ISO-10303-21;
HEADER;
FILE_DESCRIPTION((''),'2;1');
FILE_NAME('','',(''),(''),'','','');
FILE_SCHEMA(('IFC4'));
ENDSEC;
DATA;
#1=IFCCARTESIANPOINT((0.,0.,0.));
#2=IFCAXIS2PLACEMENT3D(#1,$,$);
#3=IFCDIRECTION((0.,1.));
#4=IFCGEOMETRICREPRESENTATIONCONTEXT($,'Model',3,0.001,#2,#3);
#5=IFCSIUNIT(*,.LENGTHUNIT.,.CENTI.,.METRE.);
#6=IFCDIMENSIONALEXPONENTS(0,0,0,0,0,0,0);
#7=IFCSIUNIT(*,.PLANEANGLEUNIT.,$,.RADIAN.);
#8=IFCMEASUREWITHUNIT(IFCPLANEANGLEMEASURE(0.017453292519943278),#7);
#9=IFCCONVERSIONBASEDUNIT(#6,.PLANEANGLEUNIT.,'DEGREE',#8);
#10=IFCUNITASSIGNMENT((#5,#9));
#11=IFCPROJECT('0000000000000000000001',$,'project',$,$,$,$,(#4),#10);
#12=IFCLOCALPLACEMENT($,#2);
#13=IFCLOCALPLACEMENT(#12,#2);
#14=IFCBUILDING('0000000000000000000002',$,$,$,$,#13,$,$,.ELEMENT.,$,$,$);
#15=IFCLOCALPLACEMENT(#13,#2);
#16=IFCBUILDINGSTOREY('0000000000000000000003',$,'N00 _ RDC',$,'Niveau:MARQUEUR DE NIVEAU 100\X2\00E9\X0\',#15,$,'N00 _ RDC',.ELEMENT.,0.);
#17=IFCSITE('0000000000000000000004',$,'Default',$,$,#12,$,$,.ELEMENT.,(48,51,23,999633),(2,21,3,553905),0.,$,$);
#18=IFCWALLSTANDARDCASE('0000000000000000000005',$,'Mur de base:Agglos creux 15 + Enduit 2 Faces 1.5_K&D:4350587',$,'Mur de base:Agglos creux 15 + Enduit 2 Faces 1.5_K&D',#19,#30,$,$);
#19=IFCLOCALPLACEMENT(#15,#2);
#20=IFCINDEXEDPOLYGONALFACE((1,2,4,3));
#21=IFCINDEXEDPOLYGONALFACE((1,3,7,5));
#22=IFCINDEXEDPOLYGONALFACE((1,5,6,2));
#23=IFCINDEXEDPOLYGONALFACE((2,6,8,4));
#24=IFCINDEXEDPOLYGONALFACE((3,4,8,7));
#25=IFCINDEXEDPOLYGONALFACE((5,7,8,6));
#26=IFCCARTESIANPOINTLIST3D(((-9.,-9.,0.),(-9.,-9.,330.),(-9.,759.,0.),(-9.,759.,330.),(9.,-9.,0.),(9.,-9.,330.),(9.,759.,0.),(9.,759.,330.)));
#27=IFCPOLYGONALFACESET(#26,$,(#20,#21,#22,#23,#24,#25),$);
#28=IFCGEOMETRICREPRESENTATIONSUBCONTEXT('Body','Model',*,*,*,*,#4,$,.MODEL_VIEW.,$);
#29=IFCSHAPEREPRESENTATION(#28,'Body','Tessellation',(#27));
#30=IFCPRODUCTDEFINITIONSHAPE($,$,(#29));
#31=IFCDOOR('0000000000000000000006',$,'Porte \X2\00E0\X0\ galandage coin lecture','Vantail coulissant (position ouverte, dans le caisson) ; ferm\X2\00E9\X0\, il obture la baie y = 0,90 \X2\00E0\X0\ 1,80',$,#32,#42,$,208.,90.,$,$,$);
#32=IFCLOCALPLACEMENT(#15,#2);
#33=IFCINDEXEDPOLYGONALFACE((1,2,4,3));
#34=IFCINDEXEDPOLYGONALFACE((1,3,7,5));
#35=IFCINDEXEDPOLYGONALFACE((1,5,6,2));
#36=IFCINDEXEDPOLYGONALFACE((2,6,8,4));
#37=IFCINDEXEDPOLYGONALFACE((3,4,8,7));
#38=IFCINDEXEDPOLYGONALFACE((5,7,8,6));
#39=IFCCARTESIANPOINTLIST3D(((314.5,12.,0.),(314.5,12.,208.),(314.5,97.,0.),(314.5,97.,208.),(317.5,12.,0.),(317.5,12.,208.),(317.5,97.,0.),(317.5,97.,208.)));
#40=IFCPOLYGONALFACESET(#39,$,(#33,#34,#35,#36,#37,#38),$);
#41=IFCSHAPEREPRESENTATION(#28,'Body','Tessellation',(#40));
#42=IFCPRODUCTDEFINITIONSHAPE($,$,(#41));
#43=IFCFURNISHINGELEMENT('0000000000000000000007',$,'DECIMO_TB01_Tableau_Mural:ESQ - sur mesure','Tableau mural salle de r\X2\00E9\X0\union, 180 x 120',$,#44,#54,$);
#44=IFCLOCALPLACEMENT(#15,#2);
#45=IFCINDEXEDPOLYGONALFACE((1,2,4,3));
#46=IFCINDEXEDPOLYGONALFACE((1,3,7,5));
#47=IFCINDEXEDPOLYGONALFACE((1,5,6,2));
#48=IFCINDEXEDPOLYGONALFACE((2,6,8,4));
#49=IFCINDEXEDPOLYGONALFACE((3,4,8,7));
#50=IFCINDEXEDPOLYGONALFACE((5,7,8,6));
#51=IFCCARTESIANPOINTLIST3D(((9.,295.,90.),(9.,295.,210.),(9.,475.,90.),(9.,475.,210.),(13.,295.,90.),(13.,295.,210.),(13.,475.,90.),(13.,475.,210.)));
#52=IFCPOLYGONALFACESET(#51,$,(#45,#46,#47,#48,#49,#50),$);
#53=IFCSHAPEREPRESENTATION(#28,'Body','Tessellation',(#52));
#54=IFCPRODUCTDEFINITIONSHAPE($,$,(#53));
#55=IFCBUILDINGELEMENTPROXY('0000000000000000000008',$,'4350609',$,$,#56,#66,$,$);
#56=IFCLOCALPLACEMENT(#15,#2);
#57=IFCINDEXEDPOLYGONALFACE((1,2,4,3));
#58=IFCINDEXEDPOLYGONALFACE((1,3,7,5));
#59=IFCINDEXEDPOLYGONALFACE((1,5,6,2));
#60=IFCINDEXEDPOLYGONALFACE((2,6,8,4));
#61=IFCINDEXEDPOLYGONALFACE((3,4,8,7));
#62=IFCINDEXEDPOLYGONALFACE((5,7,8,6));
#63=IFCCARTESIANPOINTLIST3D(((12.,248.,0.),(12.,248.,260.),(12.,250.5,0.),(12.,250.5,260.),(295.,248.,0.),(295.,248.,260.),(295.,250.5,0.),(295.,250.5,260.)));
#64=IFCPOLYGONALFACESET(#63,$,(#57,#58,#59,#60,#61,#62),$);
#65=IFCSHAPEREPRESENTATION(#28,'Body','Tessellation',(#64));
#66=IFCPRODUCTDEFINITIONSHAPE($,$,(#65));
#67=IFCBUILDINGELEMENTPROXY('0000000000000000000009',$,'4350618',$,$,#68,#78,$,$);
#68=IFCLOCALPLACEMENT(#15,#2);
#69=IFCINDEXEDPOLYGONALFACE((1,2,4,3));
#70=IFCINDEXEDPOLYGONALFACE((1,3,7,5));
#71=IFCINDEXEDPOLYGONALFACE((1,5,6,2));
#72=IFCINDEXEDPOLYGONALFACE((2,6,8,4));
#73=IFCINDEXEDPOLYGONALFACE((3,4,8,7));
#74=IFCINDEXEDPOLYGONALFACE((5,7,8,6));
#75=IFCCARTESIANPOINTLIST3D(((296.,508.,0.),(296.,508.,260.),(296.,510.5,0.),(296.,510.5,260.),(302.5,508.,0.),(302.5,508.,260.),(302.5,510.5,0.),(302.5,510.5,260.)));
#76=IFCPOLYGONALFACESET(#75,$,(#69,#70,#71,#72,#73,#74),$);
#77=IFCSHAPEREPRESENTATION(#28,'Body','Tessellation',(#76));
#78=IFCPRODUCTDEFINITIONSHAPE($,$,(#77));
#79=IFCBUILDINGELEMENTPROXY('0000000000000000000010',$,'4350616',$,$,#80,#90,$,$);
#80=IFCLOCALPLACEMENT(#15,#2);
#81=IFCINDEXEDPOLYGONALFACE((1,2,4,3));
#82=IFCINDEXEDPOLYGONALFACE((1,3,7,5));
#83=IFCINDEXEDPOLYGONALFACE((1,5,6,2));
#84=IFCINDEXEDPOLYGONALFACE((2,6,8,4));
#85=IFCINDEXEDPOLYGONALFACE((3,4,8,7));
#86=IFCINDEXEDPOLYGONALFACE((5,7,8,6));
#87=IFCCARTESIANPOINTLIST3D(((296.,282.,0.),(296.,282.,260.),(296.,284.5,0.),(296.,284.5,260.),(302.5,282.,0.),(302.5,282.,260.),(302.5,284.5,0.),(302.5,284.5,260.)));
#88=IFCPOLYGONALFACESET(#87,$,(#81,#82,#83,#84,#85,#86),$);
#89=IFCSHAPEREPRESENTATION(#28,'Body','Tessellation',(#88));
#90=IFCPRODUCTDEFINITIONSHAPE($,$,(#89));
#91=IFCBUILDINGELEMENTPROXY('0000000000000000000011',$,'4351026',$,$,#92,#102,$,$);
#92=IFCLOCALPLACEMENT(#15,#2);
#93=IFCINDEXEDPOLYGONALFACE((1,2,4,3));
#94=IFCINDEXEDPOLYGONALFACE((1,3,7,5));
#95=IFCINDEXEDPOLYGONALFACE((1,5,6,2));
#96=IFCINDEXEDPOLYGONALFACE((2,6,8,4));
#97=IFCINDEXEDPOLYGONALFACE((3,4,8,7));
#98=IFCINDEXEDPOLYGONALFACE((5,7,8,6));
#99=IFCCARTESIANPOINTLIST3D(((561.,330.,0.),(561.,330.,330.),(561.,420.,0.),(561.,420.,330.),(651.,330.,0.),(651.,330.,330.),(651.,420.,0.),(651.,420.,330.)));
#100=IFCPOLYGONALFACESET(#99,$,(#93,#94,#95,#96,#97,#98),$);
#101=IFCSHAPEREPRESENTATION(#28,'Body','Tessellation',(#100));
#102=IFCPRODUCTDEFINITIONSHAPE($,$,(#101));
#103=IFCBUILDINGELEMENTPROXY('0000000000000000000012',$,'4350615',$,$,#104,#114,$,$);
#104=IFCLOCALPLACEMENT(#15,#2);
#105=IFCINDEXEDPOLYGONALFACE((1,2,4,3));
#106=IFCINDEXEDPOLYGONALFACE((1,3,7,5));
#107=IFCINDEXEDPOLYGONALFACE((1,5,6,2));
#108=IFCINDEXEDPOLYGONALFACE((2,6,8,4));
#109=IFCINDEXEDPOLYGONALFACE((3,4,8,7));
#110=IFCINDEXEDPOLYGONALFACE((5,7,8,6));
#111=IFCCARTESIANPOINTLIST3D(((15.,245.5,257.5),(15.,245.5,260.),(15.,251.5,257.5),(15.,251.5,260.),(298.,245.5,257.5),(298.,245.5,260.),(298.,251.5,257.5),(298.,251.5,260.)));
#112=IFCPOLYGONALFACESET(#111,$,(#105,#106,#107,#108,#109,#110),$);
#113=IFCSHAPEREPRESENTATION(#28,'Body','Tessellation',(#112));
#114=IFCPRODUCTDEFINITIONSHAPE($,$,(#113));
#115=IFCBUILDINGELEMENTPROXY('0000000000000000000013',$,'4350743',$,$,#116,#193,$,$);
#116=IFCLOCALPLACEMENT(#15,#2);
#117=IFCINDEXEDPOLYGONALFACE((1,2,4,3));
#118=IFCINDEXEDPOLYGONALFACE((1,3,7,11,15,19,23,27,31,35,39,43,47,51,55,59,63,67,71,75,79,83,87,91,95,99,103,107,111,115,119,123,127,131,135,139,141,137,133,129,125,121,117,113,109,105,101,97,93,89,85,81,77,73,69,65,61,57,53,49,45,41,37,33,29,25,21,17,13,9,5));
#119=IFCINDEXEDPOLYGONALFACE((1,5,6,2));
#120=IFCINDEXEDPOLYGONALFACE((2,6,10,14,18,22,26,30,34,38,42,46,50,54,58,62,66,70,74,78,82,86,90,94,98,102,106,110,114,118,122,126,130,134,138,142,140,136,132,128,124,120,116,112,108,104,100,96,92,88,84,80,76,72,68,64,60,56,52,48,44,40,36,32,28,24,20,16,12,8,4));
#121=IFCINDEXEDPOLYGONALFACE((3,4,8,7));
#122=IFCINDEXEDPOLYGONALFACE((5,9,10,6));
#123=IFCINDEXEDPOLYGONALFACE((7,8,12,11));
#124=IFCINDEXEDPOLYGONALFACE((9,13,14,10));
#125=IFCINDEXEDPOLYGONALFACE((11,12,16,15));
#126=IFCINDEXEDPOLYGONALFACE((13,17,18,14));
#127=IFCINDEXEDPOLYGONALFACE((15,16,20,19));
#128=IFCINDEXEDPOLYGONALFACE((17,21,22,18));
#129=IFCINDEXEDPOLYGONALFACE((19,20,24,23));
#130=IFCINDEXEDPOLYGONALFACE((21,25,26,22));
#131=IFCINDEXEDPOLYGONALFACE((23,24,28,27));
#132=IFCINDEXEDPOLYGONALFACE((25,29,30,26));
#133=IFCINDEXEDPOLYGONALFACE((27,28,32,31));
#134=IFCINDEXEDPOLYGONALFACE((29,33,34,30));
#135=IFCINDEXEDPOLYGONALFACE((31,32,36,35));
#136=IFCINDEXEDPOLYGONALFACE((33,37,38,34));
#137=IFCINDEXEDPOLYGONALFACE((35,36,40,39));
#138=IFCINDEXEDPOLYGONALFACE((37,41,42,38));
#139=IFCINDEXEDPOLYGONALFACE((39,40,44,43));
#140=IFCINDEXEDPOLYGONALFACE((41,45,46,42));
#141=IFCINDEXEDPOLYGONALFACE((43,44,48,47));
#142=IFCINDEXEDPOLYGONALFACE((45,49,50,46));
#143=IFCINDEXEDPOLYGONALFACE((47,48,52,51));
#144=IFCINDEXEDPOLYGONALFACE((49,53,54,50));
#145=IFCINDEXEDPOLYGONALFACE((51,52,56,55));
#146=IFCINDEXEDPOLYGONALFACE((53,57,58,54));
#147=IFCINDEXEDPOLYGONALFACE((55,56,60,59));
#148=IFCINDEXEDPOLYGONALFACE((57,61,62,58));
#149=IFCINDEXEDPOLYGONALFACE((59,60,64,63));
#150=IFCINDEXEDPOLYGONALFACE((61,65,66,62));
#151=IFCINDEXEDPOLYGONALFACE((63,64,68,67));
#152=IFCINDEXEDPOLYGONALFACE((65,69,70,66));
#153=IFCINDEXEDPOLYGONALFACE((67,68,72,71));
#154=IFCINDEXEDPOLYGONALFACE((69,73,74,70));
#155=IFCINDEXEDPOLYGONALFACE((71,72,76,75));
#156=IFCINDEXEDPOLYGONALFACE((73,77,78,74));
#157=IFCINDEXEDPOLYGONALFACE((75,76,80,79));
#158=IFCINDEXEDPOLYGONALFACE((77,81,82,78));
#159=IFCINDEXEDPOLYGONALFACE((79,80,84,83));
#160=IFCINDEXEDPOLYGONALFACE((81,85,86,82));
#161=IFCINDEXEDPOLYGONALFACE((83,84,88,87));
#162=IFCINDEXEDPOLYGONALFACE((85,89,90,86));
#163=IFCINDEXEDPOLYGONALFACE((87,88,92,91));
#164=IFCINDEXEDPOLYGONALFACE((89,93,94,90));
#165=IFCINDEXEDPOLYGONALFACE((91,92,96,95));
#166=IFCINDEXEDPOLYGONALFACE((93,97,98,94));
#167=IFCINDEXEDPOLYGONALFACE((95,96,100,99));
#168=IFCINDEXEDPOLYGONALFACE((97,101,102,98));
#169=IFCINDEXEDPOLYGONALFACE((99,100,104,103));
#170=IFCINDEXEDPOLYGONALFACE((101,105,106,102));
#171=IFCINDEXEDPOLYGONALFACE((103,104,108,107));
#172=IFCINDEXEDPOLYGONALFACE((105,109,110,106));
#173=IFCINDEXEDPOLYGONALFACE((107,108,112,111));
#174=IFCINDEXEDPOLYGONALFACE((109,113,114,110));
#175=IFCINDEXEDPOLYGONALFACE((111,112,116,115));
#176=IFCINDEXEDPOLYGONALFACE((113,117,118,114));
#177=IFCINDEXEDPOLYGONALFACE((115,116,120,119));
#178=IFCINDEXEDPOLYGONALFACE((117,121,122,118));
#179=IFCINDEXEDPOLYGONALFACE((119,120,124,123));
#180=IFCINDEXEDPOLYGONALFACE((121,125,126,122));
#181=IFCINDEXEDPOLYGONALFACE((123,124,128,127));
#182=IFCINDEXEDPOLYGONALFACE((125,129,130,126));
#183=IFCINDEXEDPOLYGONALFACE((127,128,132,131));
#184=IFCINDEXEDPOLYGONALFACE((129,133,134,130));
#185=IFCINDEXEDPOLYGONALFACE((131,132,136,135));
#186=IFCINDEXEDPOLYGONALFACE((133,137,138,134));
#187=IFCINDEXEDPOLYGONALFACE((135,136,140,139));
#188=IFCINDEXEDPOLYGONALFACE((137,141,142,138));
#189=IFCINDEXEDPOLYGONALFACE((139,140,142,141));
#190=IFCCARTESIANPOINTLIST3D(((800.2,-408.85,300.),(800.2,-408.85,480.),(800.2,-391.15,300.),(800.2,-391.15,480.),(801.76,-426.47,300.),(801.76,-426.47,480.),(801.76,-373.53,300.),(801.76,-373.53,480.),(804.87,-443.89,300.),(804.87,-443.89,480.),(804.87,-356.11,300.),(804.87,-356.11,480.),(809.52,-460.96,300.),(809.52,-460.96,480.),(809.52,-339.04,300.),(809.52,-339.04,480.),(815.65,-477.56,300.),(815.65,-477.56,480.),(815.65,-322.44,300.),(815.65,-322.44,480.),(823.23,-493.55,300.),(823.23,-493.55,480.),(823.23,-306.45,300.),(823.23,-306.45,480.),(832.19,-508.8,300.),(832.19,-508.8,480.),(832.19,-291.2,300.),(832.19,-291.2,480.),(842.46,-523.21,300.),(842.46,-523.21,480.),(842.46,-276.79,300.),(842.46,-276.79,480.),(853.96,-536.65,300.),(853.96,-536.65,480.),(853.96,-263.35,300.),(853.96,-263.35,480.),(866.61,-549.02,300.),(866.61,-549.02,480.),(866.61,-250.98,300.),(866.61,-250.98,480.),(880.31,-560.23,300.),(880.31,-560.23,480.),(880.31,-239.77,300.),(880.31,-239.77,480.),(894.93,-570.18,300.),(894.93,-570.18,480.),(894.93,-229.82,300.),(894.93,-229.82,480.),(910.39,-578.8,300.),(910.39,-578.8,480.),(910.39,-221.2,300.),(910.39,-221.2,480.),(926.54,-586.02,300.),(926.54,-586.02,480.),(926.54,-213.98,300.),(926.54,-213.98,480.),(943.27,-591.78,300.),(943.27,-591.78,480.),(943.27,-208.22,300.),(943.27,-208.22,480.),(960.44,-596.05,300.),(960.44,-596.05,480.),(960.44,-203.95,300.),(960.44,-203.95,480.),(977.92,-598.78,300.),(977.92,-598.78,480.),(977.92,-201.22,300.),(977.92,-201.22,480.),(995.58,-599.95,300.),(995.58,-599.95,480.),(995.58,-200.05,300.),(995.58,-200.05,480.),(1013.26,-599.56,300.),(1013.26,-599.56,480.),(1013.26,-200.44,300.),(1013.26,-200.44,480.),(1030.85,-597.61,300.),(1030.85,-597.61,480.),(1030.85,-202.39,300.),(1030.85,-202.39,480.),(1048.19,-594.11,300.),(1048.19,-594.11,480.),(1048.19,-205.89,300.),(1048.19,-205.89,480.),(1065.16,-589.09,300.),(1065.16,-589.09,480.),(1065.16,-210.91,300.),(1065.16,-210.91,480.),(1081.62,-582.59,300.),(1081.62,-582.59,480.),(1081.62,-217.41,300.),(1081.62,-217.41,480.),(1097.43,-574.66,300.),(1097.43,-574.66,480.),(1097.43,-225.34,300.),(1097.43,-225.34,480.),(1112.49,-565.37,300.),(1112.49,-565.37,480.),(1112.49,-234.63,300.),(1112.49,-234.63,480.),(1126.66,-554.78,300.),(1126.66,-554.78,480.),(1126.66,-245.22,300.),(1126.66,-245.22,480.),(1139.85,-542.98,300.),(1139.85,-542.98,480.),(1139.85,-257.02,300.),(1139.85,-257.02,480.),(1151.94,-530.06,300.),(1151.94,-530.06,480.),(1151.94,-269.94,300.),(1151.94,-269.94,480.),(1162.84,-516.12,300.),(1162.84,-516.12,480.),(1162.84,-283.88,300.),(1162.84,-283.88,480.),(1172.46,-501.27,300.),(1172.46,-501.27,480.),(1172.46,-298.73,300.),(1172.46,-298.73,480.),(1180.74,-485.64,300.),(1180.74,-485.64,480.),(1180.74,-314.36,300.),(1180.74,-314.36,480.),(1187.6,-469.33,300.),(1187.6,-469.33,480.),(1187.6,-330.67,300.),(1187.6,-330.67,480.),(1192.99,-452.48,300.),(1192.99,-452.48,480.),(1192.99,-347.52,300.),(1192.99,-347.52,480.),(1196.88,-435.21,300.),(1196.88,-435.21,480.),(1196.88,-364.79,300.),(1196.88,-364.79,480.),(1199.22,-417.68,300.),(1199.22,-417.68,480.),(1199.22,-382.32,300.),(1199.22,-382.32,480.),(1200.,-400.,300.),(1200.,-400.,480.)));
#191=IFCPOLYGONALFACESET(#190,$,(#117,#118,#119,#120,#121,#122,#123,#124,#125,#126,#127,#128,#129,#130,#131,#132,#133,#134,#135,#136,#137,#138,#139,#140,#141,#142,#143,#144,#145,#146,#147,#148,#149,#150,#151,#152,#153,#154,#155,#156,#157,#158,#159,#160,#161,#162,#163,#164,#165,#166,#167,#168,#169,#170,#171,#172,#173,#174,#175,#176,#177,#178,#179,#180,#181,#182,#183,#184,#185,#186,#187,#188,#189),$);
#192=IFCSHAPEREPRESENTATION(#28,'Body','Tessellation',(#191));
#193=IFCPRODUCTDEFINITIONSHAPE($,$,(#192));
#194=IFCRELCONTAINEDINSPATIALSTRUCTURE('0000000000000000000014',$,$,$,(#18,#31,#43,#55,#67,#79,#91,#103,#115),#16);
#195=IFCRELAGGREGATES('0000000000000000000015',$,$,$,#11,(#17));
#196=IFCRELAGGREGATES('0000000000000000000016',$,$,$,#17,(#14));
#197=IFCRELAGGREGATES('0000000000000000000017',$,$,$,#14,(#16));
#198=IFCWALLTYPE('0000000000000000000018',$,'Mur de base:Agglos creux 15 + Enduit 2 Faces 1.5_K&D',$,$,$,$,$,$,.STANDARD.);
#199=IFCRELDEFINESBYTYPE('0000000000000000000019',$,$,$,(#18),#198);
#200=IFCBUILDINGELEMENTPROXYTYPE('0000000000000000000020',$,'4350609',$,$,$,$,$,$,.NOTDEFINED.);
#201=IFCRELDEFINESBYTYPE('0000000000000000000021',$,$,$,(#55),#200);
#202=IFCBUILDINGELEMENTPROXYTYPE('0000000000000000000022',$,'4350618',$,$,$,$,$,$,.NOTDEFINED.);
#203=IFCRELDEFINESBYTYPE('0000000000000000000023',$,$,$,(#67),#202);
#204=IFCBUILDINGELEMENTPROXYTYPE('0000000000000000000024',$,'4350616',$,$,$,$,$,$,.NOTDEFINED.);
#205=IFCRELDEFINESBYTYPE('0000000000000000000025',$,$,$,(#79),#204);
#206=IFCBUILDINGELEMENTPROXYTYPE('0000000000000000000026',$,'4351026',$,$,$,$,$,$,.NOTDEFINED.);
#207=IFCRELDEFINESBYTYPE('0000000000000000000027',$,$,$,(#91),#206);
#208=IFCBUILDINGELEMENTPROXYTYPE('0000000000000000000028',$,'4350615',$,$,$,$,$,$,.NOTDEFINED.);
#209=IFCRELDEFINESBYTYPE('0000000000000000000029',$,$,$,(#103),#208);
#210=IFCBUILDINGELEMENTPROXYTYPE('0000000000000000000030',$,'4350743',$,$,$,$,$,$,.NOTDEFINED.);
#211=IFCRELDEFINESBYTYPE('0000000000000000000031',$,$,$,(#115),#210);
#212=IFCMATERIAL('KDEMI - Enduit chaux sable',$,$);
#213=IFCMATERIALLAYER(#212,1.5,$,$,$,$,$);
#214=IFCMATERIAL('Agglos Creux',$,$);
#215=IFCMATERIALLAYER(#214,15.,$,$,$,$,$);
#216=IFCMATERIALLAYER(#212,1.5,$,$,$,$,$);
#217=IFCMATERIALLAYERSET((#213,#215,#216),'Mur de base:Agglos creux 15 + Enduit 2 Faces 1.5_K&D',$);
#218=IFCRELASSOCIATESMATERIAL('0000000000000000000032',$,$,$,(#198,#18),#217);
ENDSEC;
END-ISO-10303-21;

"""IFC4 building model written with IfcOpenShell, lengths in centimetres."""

from ifc_helpers import new_model, entity, si_unit, converted_unit, direction, frame, frame_2d, origin, origin_with_axes, origin_2d_with_axis, place, context, subcontext, project, spatial, rectangle, circle, extrude, material, layer, layer_set, layer_usage, type_object, element, save


model = new_model("IFC4")

# Units and contexts
model_context = context("Model", 3, precision=0.001, world=origin(), true_north=direction((0.0, 1.0)))
body_context = subcontext(model_context, "Body", "Model", "MODEL_VIEW")
ifc_project = project(units=[si_unit("LENGTHUNIT", "METRE", prefix="CENTI"), converted_unit("PLANEANGLEUNIT", "DEGREE", entity("IfcPlaneAngleMeasure", 0.017453292519943278), si_unit("PLANEANGLEUNIT", "RADIAN"), dimensions=[0, 0, 0, 0, 0, 0, 0])], contexts=[model_context])

# Site, building, storey
site_placement = place(None, origin())
site = spatial("IfcSite", under=ifc_project, at=site_placement, Name="Default", CompositionType="ELEMENT", RefLatitude=(48, 51, 23, 999633), RefLongitude=(2, 21, 3, 553905), RefElevation=0.0)
building_placement = place(site_placement, origin())
building = spatial("IfcBuilding", under=site, at=building_placement, CompositionType="ELEMENT")
storey_placement = place(building_placement, origin())
storey = spatial("IfcBuildingStorey", under=building, at=storey_placement, Name="N00 _ RDC", ObjectType="Niveau:MARQUEUR DE NIVEAU 100é", LongName="N00 _ RDC", CompositionType="ELEMENT", Elevation=0.0)

# Wall
ifc_material_1 = material(Name="KDEMI - Enduit chaux sable")
ifc_layer_1 = layer(ifc_material_1, 1.5)
ifc_material_2 = material(Name="Agglos Creux")
ifc_layer_2 = layer(ifc_material_2, 15.0)
ifc_layer_3 = layer(ifc_material_1, 1.5)
ifc_layer_set = layer_set([ifc_layer_1, ifc_layer_2, ifc_layer_3], Name="Mur de base:Agglos creux 15 + Enduit 2 Faces 1.5_K&D")
ifc_layer_usage = layer_usage(ifc_layer_set, "AXIS2", "NEGATIVE", 9.0)
wall_type = type_object("IfcWallType", Name="Mur de base:Agglos creux 15 + Enduit 2 Faces 1.5_K&D", PredefinedType="STANDARD", material=ifc_layer_set)
wall_placement = place(storey_placement, frame((0.0, -9.0, 0.0), z_axis=(0.0, 0.0, 1.0), x_axis=(0.0, 1.0, 0.0)))
element("IfcWallStandardCase", 1, at=wall_placement, inside=storey, type_object=wall_type, material=ifc_layer_usage, Name="Mur de base:Agglos creux 15 + Enduit 2 Faces 1.5_K&D:4350587", ObjectType="Mur de base:Agglos creux 15 + Enduit 2 Faces 1.5_K&D", context=body_context, shape_type="SweptSolid", body=[
    extrude(rectangle(XDim=768.0, YDim=18.0, at=frame_2d((384.0, 0.0), x_axis=(-1.0, 0.0))), origin(), (0.0, 0.0, 1.0), 330.0),
])

# Door
door_placement = place(storey_placement, origin_with_axes())
element("IfcDoor", 2, at=door_placement, inside=storey, Name="Porte à galandage coin lecture", Description="Vantail coulissant (position ouverte, dans le caisson) ; fermé, il obture la baie y = 0,90 à 1,80", OverallHeight=208.0, OverallWidth=90.0, context=body_context, shape_type="SweptSolid", body=[
    extrude(rectangle(XDim=3.0, YDim=85.0, at=frame_2d((316.0, 54.5))), origin(), (0.0, 0.0, 1.0), 208.0),
])

# Furnishing element
furnishing_placement = place(storey_placement, origin_with_axes())
element("IfcFurnishingElement", 3, at=furnishing_placement, inside=storey, Name="DECIMO_TB01_Tableau_Mural:ESQ - sur mesure", Description="Tableau mural salle de réunion, 180 x 120", context=body_context, shape_type="SweptSolid", body=[
    extrude(rectangle(XDim=4.0, YDim=180.0, at=frame_2d((11.0, 385.0))), frame((0.0, 0.0, 90.0)), (0.0, 0.0, 1.0), 120.0),
])

# Building element proxies
building_element_proxy_type_1 = type_object("IfcBuildingElementProxyType", Name="4350609", PredefinedType="NOTDEFINED")
proxy_1_placement = place(storey_placement, origin())
element("IfcBuildingElementProxy", 4, at=proxy_1_placement, inside=storey, type_object=building_element_proxy_type_1, Name="4350609", context=body_context, shape_type="SweptSolid", body=[
    extrude(rectangle(XDim=283.0, YDim=2.5, at=frame_2d((0.0, 0.0), x_axis=(1.0, 0.0))), frame((153.5, 249.25, 0.0)), (0.0, 0.0, 1.0), 260.0),
])
building_element_proxy_type_2 = type_object("IfcBuildingElementProxyType", Name="4350618", PredefinedType="NOTDEFINED")
proxy_2_placement = place(storey_placement, origin())
element("IfcBuildingElementProxy", 5, at=proxy_2_placement, inside=storey, type_object=building_element_proxy_type_2, Name="4350618", context=body_context, shape_type="SweptSolid", body=[
    extrude(rectangle(XDim=6.5, YDim=2.5, at=frame_2d((0.0, 0.0), x_axis=(1.0, 0.0))), frame((299.25, 509.25, 0.0)), (0.0, 0.0, 1.0), 260.0),
])
building_element_proxy_type_3 = type_object("IfcBuildingElementProxyType", Name="4350616", PredefinedType="NOTDEFINED")
proxy_3_placement = place(storey_placement, origin())
element("IfcBuildingElementProxy", 6, at=proxy_3_placement, inside=storey, type_object=building_element_proxy_type_3, Name="4350616", context=body_context, shape_type="SweptSolid", body=[
    extrude(rectangle(XDim=6.5, YDim=2.5, at=frame_2d((0.0, 0.0), x_axis=(1.0, 0.0))), frame((299.25, 283.25, 0.0)), (0.0, 0.0, 1.0), 260.0),
])
building_element_proxy_type_4 = type_object("IfcBuildingElementProxyType", Name="4351026", PredefinedType="NOTDEFINED")
proxy_4_placement = place(storey_placement, origin())
element("IfcBuildingElementProxy", 7, at=proxy_4_placement, inside=storey, type_object=building_element_proxy_type_4, Name="4351026", context=body_context, shape_type="SweptSolid", body=[
    extrude(rectangle(XDim=90.0, YDim=90.0, at=frame_2d((0.0, 0.0), x_axis=(1.0, 0.0))), frame((606.0, 375.0, 0.0)), (0.0, 0.0, 1.0), 330.0),
])
building_element_proxy_type_5 = type_object("IfcBuildingElementProxyType", Name="4350615", PredefinedType="NOTDEFINED")
proxy_5_placement = place(storey_placement, origin())
element("IfcBuildingElementProxy", 8, at=proxy_5_placement, inside=storey, type_object=building_element_proxy_type_5, Name="4350615", context=body_context, shape_type="SweptSolid", body=[
    extrude(rectangle(XDim=283.0, YDim=6.0, at=frame_2d((0.0, 0.0), x_axis=(1.0, 0.0))), frame((156.5, 248.5, 257.5)), (0.0, 0.0, 1.0), 2.5),
])
building_element_proxy_type_6 = type_object("IfcBuildingElementProxyType", Name="4350743", PredefinedType="NOTDEFINED")
proxy_6_placement = place(storey_placement, origin())
element("IfcBuildingElementProxy", 9, at=proxy_6_placement, inside=storey, type_object=building_element_proxy_type_6, Name="4350743", context=body_context, shape_type="SweptSolid", body=[
    extrude(circle(Radius=200.0, at=origin_2d_with_axis()), frame((1000.0, -400.0, 300.0)), (0.0, 0.0, 1.0), 180.0),
])

save(model, "model.ifc")
